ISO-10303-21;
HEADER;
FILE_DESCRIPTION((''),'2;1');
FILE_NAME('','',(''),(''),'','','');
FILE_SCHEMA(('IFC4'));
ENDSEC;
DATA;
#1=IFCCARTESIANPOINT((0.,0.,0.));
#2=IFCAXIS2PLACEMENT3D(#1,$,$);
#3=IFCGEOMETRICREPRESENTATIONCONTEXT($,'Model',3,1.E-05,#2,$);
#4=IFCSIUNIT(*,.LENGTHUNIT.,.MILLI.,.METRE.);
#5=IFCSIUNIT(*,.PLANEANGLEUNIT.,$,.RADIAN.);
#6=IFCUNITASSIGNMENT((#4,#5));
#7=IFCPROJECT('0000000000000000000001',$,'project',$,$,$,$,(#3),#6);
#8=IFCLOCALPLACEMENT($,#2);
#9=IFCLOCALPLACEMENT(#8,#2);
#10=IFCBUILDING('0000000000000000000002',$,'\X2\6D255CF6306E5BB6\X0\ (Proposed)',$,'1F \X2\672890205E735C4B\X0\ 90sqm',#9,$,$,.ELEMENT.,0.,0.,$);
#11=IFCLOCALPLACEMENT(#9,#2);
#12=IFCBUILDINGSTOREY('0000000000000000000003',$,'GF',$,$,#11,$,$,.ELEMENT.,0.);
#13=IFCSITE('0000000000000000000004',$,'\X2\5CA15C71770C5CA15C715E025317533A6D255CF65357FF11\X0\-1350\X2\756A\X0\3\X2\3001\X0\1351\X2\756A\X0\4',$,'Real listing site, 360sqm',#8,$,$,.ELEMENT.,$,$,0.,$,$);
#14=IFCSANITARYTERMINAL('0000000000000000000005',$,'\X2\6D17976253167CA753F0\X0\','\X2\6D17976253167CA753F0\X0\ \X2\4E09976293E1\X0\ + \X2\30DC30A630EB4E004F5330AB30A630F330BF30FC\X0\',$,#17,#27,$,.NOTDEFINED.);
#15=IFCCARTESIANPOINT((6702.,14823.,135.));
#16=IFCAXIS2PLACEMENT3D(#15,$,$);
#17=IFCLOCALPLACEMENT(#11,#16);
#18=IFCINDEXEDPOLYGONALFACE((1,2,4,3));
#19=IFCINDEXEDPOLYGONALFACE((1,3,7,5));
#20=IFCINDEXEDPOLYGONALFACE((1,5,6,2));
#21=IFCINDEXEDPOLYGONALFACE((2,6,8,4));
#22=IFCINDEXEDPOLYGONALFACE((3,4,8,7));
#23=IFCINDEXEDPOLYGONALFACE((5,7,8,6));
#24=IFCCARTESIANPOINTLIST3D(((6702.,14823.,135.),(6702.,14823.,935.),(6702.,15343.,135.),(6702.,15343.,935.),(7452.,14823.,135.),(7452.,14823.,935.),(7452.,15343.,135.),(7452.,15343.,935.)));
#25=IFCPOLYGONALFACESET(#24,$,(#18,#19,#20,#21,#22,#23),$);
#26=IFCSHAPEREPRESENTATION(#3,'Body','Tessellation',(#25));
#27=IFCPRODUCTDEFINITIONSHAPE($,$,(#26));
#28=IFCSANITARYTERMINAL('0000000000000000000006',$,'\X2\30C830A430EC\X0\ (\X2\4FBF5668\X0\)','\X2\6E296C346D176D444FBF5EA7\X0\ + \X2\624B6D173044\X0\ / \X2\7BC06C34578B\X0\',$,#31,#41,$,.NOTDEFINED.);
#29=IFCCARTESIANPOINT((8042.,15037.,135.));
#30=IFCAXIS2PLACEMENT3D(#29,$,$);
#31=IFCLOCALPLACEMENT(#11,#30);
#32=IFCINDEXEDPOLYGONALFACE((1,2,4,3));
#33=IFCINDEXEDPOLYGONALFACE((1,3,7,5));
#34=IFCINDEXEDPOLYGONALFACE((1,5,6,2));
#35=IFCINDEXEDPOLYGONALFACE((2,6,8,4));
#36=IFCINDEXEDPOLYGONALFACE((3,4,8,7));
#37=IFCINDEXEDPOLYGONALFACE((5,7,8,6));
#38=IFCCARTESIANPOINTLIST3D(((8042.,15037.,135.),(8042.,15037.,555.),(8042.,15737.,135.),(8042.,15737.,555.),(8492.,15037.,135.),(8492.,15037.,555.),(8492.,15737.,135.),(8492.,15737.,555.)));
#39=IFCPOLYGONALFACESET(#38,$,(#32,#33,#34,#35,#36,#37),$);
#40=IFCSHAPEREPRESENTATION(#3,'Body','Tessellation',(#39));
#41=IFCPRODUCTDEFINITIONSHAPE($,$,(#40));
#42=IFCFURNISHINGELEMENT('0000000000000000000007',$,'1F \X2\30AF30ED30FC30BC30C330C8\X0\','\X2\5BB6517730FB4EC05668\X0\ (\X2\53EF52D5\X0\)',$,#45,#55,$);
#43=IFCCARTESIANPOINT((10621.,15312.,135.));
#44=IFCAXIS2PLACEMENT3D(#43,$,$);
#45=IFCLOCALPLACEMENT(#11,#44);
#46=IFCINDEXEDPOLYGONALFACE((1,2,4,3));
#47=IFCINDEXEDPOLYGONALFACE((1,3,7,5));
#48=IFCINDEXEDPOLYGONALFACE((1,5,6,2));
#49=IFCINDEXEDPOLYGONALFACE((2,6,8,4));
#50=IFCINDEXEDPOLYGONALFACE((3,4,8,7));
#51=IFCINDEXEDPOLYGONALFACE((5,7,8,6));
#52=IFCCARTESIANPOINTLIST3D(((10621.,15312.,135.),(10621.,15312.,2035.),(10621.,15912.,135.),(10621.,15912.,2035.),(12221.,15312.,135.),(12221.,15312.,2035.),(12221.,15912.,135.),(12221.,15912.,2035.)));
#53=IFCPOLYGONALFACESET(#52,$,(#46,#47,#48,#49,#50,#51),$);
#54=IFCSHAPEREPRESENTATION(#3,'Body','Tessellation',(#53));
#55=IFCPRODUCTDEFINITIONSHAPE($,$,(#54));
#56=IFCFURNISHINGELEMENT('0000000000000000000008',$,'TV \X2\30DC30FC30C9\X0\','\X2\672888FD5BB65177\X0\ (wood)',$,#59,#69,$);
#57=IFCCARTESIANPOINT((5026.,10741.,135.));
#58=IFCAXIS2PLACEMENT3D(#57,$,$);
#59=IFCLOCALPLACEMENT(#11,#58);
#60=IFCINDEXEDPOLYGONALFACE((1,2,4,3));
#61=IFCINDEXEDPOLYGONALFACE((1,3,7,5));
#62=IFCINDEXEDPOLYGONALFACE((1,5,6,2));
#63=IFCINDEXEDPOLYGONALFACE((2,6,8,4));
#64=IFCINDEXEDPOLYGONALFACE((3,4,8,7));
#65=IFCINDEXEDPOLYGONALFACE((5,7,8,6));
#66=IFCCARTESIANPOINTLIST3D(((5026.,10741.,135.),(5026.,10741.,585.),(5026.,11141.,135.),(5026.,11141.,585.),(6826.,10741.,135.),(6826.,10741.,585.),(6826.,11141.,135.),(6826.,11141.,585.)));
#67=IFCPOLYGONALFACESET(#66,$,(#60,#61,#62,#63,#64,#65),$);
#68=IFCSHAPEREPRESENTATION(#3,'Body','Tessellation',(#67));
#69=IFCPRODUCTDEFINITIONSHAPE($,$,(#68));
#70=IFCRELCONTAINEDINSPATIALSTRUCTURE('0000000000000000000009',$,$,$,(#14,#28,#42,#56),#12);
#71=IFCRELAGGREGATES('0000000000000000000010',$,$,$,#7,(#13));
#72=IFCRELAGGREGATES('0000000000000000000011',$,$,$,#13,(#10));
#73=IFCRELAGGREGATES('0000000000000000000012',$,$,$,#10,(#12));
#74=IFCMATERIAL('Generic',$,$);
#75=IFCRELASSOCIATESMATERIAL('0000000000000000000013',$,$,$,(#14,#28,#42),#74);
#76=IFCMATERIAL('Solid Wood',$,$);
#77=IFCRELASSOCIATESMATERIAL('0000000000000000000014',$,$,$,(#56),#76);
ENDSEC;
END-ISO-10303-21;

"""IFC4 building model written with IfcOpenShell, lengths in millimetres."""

from ifc_helpers import new_model, si_unit, frame, frame_2d, origin, place, context, project, spatial, rectangle, extrude, material, element, save


model = new_model("IFC4")

# Units and contexts
model_context = context("Model", 3, precision=1e-05, world=origin())
ifc_project = project(units=[si_unit("LENGTHUNIT", "METRE", prefix="MILLI"), si_unit("PLANEANGLEUNIT", "RADIAN")], contexts=[model_context])

# Site, building, storey
site_placement = place(None, origin())
site = spatial("IfcSite", under=ifc_project, at=site_placement, Name="岡山県岡山市北区津島南１-1350番3、1351番4", ObjectType="Real listing site, 360sqm", CompositionType="ELEMENT", RefElevation=0.0)
building_placement = place(site_placement, origin())
building = spatial("IfcBuilding", under=site, at=building_placement, Name="津島の家 (Proposed)", ObjectType="1F 木造平屋 90sqm", CompositionType="ELEMENT", ElevationOfRefHeight=0.0, ElevationOfTerrain=0.0)
storey_placement = place(building_placement, origin())
storey = spatial("IfcBuildingStorey", under=building, at=storey_placement, Name="GF", CompositionType="ELEMENT", Elevation=0.0)

# Shared definitions
ifc_material_1 = material(Name="Solid Wood")

# Sanitary terminals
ifc_material_2 = material(Name="Generic")
sanitary_terminal_1_placement = place(storey_placement, frame((6702.0, 14823.0, 135.0)))
element("IfcSanitaryTerminal", 1, at=sanitary_terminal_1_placement, inside=storey, material=ifc_material_2, Name="洗面化粧台", Description="洗面化粧台 三面鏡 + ボウル一体カウンター", PredefinedType="NOTDEFINED", context=model_context, shape_type="SweptSolid", body=[
    extrude(rectangle(XDim=750.0, YDim=520.0, at=frame_2d((375.0, 260.0))), frame((6702.0, 14823.0, 135.0)), (0.0, 0.0, 1.0), 800.0),
])
sanitary_terminal_2_placement = place(storey_placement, frame((8042.0, 15037.0, 135.0)))
element("IfcSanitaryTerminal", 2, at=sanitary_terminal_2_placement, inside=storey, material=ifc_material_2, Name="トイレ (便器)", Description="温水洗浄便座 + 手洗い / 節水型", PredefinedType="NOTDEFINED", context=model_context, shape_type="SweptSolid", body=[
    extrude(rectangle(XDim=450.0, YDim=700.0, at=frame_2d((225.0, 350.0))), frame((8042.0, 15037.0, 135.0)), (0.0, 0.0, 1.0), 420.0),
])

# Furnishing elements
furnishing_1_placement = place(storey_placement, frame((10621.0, 15312.0, 135.0)))
element("IfcFurnishingElement", 3, at=furnishing_1_placement, inside=storey, material=ifc_material_2, Name="1F クローゼット", Description="家具・什器 (可動)", context=model_context, shape_type="SweptSolid", body=[
    extrude(rectangle(XDim=1600.0, YDim=600.0, at=frame_2d((800.0, 300.0))), frame((10621.0, 15312.0, 135.0)), (0.0, 0.0, 1.0), 1900.0),
])
furnishing_2_placement = place(storey_placement, frame((5026.0, 10741.0, 135.0)))
element("IfcFurnishingElement", 4, at=furnishing_2_placement, inside=storey, material=ifc_material_1, Name="TV ボード", Description="木製家具 (wood)", context=model_context, shape_type="SweptSolid", body=[
    extrude(rectangle(XDim=1800.0, YDim=400.0, at=frame_2d((900.0, 200.0))), frame((5026.0, 10741.0, 135.0)), (0.0, 0.0, 1.0), 450.0),
])

save(model, "model.ifc")
